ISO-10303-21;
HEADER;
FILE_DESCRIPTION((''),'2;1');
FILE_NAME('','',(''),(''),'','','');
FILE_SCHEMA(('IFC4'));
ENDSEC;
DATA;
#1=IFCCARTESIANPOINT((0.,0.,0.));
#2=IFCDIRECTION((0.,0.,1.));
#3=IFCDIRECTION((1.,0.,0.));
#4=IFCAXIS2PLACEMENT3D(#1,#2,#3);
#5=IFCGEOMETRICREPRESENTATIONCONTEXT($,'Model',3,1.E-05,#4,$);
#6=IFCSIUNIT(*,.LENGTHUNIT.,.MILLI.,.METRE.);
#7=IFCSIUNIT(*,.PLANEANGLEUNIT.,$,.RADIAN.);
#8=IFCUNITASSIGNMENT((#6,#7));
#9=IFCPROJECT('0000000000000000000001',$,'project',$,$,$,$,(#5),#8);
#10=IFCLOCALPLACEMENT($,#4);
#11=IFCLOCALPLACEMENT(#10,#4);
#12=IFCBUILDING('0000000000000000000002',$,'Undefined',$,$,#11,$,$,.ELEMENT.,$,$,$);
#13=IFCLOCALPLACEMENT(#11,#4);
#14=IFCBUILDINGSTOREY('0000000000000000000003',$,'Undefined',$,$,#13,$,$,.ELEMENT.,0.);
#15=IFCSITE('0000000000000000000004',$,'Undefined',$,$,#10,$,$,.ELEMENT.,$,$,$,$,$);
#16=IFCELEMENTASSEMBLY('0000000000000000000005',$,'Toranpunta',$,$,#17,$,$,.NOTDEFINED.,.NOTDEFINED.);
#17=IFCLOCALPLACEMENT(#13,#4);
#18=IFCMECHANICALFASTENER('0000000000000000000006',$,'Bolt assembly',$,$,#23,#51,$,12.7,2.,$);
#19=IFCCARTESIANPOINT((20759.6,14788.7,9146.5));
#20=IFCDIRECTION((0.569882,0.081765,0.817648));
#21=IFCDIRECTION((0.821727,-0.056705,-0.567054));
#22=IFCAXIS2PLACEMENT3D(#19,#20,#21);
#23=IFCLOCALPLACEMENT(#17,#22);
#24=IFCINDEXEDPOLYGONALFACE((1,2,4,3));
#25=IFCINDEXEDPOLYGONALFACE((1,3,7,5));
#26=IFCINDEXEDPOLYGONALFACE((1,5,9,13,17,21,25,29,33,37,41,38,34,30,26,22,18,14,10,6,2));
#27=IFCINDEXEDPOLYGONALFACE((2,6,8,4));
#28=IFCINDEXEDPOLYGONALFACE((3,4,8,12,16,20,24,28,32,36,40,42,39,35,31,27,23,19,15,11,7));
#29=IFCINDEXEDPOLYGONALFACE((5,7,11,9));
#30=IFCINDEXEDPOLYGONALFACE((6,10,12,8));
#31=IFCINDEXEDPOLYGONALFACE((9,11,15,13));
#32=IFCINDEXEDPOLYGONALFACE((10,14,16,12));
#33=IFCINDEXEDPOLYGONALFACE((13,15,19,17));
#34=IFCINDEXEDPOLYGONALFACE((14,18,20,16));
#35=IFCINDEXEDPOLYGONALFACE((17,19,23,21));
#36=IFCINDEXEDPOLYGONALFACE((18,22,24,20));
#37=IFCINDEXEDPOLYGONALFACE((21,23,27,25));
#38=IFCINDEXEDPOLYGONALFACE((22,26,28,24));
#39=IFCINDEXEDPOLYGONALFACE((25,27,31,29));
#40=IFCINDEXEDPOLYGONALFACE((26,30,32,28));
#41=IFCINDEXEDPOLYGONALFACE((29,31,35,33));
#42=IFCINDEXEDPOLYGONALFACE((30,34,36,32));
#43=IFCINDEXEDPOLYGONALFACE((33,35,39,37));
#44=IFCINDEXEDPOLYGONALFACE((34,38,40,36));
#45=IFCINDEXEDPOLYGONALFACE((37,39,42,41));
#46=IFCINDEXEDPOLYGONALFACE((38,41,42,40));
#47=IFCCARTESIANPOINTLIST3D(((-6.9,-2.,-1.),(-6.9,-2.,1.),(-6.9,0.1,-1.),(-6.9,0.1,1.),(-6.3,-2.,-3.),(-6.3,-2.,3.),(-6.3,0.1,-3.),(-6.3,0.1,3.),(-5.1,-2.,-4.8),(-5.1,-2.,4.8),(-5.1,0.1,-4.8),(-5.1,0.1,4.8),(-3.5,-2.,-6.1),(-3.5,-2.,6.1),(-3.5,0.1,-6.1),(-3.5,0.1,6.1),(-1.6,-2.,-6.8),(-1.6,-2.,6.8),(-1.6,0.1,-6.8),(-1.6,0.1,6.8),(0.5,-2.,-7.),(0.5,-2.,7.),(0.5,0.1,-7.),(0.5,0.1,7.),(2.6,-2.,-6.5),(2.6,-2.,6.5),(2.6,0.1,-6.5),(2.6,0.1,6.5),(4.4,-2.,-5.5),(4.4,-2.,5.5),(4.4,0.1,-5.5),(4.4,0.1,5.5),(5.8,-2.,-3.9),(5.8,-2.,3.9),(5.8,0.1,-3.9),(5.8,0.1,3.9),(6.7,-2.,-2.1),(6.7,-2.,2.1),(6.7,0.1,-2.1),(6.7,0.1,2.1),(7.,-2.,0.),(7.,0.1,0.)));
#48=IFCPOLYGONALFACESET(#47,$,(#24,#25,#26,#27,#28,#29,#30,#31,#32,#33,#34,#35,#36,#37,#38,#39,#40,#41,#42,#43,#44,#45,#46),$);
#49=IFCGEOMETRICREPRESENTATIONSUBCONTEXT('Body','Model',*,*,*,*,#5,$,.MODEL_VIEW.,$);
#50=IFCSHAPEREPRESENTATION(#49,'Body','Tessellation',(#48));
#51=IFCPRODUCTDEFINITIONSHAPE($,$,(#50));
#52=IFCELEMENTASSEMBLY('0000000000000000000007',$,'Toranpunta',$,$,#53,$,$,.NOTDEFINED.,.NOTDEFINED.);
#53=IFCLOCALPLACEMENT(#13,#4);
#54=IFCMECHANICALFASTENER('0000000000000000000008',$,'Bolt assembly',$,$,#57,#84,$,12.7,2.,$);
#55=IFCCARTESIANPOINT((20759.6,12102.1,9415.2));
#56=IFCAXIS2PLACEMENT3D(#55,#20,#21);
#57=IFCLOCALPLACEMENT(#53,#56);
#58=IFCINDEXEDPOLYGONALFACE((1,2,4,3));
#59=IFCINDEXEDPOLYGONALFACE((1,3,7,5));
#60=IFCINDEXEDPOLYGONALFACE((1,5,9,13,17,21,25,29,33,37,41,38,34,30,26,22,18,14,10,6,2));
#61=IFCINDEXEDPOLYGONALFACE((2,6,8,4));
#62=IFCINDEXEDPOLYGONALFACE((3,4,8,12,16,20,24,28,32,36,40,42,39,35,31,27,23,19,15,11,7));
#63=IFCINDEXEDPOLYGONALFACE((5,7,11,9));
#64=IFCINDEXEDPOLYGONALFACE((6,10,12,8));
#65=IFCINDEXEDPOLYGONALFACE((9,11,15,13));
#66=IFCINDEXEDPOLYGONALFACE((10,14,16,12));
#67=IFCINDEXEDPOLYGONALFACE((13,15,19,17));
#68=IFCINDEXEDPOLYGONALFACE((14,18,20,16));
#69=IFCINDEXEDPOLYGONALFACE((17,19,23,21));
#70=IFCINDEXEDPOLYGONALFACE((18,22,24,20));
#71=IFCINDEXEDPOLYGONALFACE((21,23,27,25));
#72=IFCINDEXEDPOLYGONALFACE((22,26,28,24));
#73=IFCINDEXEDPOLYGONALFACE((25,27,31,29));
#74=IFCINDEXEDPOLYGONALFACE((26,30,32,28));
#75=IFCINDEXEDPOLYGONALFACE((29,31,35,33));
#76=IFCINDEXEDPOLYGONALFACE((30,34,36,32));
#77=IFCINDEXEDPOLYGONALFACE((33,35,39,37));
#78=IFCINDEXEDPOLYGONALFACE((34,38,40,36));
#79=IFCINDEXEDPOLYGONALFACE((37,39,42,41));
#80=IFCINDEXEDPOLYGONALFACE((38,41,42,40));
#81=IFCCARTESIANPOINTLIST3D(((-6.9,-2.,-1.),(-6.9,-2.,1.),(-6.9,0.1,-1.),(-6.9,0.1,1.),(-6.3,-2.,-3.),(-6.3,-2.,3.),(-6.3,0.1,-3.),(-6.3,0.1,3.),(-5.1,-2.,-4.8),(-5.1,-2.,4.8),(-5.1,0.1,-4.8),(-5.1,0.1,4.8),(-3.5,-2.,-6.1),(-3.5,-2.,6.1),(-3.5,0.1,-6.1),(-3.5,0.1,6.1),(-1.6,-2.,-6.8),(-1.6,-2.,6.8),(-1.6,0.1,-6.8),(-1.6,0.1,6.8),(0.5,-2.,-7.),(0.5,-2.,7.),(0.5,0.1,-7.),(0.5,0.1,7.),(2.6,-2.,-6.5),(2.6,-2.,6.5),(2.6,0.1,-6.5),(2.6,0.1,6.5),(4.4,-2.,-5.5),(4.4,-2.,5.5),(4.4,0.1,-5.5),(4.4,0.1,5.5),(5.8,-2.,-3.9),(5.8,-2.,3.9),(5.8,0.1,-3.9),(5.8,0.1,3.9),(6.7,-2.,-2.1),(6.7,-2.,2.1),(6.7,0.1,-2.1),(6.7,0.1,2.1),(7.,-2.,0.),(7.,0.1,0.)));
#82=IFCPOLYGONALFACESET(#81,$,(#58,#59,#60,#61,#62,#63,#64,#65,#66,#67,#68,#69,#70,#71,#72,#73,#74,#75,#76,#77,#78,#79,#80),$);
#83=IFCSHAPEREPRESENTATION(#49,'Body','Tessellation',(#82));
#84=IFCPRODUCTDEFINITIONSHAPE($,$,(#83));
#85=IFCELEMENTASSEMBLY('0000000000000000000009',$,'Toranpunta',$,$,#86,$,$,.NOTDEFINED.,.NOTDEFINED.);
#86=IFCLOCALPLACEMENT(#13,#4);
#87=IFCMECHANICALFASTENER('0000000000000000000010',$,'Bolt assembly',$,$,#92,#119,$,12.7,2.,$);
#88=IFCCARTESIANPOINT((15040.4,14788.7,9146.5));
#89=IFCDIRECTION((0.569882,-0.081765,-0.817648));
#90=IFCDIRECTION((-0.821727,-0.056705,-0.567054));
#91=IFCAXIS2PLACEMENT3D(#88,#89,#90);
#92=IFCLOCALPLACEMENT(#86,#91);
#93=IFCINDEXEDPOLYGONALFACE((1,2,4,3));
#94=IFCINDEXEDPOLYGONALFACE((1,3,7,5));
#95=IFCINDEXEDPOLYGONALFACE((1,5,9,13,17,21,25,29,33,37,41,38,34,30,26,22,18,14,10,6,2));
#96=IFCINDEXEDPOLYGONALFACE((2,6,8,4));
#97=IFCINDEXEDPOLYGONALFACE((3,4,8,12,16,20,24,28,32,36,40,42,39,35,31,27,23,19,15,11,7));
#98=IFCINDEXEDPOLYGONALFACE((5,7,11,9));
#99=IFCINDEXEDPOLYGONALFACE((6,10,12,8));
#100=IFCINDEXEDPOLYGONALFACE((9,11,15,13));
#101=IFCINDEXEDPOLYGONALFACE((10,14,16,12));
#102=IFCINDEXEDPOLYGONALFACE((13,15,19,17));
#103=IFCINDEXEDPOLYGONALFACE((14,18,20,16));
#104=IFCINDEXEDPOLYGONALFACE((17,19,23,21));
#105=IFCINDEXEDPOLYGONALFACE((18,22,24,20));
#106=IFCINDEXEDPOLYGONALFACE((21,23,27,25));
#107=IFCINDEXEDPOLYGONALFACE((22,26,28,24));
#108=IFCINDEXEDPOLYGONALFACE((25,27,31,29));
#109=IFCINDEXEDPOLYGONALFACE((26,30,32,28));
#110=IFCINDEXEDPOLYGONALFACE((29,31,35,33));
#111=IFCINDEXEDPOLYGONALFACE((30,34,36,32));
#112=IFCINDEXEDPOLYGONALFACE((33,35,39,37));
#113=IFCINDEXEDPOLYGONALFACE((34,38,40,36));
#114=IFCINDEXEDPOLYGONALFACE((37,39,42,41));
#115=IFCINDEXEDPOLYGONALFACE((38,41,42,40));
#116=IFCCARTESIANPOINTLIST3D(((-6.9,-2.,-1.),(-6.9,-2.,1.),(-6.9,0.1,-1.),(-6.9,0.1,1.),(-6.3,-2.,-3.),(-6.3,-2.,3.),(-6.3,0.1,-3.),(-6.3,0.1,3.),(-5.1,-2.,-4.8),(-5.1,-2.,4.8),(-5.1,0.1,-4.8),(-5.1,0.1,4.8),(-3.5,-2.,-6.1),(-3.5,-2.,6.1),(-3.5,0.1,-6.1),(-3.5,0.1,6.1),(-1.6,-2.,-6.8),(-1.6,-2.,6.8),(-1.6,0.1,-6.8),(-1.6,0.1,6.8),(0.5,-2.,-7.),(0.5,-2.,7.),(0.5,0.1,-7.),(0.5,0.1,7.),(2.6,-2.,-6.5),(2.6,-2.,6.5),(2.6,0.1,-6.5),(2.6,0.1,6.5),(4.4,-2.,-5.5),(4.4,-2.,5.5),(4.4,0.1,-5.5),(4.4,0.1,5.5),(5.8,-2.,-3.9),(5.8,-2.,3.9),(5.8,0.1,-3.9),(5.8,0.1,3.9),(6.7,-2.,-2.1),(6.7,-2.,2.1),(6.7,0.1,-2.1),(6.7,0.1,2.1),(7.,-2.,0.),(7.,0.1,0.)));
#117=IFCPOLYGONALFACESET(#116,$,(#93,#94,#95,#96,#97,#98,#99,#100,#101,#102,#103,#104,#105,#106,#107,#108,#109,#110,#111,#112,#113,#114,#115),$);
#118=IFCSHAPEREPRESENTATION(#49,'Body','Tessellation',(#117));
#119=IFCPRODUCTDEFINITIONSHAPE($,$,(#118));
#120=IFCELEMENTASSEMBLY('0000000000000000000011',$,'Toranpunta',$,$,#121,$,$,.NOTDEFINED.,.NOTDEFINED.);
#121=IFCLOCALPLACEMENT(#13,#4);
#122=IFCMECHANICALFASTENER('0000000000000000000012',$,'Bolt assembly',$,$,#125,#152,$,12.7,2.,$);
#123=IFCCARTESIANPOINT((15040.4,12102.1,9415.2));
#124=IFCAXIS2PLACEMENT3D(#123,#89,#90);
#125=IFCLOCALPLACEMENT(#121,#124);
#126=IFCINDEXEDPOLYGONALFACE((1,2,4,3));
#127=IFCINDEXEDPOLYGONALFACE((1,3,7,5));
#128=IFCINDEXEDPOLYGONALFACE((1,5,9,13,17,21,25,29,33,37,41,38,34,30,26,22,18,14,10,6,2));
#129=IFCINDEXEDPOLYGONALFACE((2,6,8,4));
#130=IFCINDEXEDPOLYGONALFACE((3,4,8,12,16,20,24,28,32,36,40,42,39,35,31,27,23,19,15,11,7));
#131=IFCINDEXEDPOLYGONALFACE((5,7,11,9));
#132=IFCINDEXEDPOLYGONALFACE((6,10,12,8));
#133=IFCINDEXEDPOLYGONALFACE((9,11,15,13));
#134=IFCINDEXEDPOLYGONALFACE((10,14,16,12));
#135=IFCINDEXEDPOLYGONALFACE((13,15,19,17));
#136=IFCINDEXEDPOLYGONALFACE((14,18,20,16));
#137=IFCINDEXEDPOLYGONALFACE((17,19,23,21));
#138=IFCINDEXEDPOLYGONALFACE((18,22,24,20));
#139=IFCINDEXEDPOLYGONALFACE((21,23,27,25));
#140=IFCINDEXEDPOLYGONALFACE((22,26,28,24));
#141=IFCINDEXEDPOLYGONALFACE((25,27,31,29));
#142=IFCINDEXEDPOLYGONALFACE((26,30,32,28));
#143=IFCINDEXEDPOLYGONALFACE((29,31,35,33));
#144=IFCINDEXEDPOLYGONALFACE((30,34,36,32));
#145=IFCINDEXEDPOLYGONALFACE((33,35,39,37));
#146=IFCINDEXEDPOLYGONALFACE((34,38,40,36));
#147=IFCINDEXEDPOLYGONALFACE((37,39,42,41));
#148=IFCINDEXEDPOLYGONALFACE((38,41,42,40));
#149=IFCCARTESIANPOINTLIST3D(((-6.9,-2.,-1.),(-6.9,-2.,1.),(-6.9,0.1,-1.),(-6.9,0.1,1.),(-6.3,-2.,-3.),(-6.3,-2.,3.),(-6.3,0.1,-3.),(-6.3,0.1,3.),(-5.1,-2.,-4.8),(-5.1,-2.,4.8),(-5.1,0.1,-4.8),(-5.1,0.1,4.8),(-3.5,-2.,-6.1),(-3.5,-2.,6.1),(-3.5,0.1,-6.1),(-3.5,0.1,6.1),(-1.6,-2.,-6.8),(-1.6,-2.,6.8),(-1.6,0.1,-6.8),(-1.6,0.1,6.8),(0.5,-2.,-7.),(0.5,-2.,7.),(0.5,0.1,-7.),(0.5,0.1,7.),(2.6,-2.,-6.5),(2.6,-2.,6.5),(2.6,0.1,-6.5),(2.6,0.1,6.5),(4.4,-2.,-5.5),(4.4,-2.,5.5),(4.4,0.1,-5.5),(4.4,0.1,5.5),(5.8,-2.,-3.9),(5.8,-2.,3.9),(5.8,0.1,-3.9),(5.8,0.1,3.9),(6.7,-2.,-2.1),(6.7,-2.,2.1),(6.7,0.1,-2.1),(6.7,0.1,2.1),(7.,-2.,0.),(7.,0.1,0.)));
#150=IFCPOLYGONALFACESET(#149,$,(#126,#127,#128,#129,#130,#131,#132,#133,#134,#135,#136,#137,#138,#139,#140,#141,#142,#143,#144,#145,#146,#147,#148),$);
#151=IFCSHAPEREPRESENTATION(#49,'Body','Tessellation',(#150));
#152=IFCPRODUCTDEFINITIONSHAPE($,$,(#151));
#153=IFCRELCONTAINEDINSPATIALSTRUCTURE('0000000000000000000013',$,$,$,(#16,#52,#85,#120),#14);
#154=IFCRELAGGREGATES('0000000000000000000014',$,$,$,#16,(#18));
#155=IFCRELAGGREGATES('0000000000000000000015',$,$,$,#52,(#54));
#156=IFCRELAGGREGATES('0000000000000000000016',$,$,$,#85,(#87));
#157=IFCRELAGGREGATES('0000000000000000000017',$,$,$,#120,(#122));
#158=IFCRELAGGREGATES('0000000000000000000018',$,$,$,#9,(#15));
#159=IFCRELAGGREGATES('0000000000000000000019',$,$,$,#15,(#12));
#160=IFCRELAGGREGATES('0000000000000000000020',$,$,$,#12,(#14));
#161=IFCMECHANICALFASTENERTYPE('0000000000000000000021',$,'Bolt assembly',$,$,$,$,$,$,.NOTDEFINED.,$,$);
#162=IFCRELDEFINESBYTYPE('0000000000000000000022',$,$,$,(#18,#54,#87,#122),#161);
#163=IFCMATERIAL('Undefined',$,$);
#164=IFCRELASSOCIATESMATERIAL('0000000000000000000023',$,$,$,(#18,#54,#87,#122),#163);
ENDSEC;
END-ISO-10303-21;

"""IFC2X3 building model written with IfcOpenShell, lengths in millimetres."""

from ifc_helpers import new_model, si_unit, frame, origin_with_axes, origin_2d_with_axis, place, context, subcontext, project, spatial, circle, extrude, source, transform, mapped, material, type_object, element, aggregate, save


model = new_model("IFC2X3")

# Units and contexts
model_context = context("Model", 3, precision=1e-05, world=origin_with_axes())
body_context = subcontext(model_context, "Body", "Model", "MODEL_VIEW")
ifc_project = project(units=[si_unit("LENGTHUNIT", "METRE", prefix="MILLI"), si_unit("PLANEANGLEUNIT", "RADIAN")], contexts=[model_context])

# Site, building, storey
site_placement = place(None, origin_with_axes())
site = spatial("IfcSite", under=ifc_project, at=site_placement, Name="Undefined", CompositionType="ELEMENT")
building_placement = place(site_placement, origin_with_axes())
building = spatial("IfcBuilding", under=site, at=building_placement, Name="Undefined", CompositionType="ELEMENT")
storey_placement = place(building_placement, origin_with_axes())
storey = spatial("IfcBuildingStorey", under=building, at=storey_placement, Name="Undefined", CompositionType="ELEMENT", Elevation=0.0)

# Shared definitions
ifc_material_1 = material(Name="Undefined")
mechanical_fastener_type = type_object("IfcMechanicalFastenerType", Name="Bolt assembly")

# Element assemblies, mechanical fasteners
assembly_1_placement = place(storey_placement, origin_with_axes())
assembly_1 = element("IfcElementAssembly", 1, at=assembly_1_placement, inside=storey, Name="Toranpunta", AssemblyPlace="NOTDEFINED", PredefinedType="NOTDEFINED")
shared_shape_1 = source(origin_with_axes(), body_context, "Body", "SweptSolid", [
    extrude(circle(Radius=7.0, at=origin_2d_with_axis()), frame((0.0, -2.0, 0.0), z_axis=(0.0, 1.0, 0.0), x_axis=(1.0, 0.0, 0.0)), (0.0, 0.0, 1.0), 2.1),
])
mechanical_fastener_1_placement = place(assembly_1_placement, frame((20759.6, 14788.7, 9146.5), z_axis=(0.569882, 0.081765, 0.817648), x_axis=(0.821727, -0.056705, -0.567054)))
mechanical_fastener_1 = element("IfcMechanicalFastener", 2, at=mechanical_fastener_1_placement, type_object=mechanical_fastener_type, material=ifc_material_1, Name="Bolt assembly", NominalDiameter=12.7, NominalLength=2.0, context=body_context, shape_type="MappedRepresentation", body=[
    mapped(shared_shape_1, transform((0.0, 0.0, 0.0))),
])
aggregate(assembly_1, [mechanical_fastener_1])
assembly_2_placement = place(storey_placement, origin_with_axes())
assembly_2 = element("IfcElementAssembly", 3, at=assembly_2_placement, inside=storey, Name="Toranpunta", AssemblyPlace="NOTDEFINED", PredefinedType="NOTDEFINED")
mechanical_fastener_2_placement = place(assembly_2_placement, frame((20759.6, 12102.1, 9415.2), z_axis=(0.569882, 0.081765, 0.817648), x_axis=(0.821727, -0.056705, -0.567054)))
mechanical_fastener_2 = element("IfcMechanicalFastener", 4, at=mechanical_fastener_2_placement, type_object=mechanical_fastener_type, material=ifc_material_1, Name="Bolt assembly", NominalDiameter=12.7, NominalLength=2.0, context=body_context, shape_type="MappedRepresentation", body=[
    mapped(shared_shape_1, transform((0.0, 0.0, 0.0))),
])
aggregate(assembly_2, [mechanical_fastener_2])
assembly_3_placement = place(storey_placement, origin_with_axes())
assembly_3 = element("IfcElementAssembly", 5, at=assembly_3_placement, inside=storey, Name="Toranpunta", AssemblyPlace="NOTDEFINED", PredefinedType="NOTDEFINED")
mechanical_fastener_3_placement = place(assembly_3_placement, frame((15040.4, 14788.7, 9146.5), z_axis=(0.569882, -0.081765, -0.817648), x_axis=(-0.821727, -0.056705, -0.567054)))
mechanical_fastener_3 = element("IfcMechanicalFastener", 6, at=mechanical_fastener_3_placement, type_object=mechanical_fastener_type, material=ifc_material_1, Name="Bolt assembly", NominalDiameter=12.7, NominalLength=2.0, context=body_context, shape_type="MappedRepresentation", body=[
    mapped(shared_shape_1, transform((0.0, 0.0, 0.0))),
])
aggregate(assembly_3, [mechanical_fastener_3])
assembly_4_placement = place(storey_placement, origin_with_axes())
assembly_4 = element("IfcElementAssembly", 7, at=assembly_4_placement, inside=storey, Name="Toranpunta", AssemblyPlace="NOTDEFINED", PredefinedType="NOTDEFINED")
mechanical_fastener_4_placement = place(assembly_4_placement, frame((15040.4, 12102.1, 9415.2), z_axis=(0.569882, -0.081765, -0.817648), x_axis=(-0.821727, -0.056705, -0.567054)))
mechanical_fastener_4 = element("IfcMechanicalFastener", 8, at=mechanical_fastener_4_placement, type_object=mechanical_fastener_type, material=ifc_material_1, Name="Bolt assembly", NominalDiameter=12.7, NominalLength=2.0, context=body_context, shape_type="MappedRepresentation", body=[
    mapped(shared_shape_1, transform((0.0, 0.0, 0.0))),
])
aggregate(assembly_4, [mechanical_fastener_4])

save(model, "model.ifc")
